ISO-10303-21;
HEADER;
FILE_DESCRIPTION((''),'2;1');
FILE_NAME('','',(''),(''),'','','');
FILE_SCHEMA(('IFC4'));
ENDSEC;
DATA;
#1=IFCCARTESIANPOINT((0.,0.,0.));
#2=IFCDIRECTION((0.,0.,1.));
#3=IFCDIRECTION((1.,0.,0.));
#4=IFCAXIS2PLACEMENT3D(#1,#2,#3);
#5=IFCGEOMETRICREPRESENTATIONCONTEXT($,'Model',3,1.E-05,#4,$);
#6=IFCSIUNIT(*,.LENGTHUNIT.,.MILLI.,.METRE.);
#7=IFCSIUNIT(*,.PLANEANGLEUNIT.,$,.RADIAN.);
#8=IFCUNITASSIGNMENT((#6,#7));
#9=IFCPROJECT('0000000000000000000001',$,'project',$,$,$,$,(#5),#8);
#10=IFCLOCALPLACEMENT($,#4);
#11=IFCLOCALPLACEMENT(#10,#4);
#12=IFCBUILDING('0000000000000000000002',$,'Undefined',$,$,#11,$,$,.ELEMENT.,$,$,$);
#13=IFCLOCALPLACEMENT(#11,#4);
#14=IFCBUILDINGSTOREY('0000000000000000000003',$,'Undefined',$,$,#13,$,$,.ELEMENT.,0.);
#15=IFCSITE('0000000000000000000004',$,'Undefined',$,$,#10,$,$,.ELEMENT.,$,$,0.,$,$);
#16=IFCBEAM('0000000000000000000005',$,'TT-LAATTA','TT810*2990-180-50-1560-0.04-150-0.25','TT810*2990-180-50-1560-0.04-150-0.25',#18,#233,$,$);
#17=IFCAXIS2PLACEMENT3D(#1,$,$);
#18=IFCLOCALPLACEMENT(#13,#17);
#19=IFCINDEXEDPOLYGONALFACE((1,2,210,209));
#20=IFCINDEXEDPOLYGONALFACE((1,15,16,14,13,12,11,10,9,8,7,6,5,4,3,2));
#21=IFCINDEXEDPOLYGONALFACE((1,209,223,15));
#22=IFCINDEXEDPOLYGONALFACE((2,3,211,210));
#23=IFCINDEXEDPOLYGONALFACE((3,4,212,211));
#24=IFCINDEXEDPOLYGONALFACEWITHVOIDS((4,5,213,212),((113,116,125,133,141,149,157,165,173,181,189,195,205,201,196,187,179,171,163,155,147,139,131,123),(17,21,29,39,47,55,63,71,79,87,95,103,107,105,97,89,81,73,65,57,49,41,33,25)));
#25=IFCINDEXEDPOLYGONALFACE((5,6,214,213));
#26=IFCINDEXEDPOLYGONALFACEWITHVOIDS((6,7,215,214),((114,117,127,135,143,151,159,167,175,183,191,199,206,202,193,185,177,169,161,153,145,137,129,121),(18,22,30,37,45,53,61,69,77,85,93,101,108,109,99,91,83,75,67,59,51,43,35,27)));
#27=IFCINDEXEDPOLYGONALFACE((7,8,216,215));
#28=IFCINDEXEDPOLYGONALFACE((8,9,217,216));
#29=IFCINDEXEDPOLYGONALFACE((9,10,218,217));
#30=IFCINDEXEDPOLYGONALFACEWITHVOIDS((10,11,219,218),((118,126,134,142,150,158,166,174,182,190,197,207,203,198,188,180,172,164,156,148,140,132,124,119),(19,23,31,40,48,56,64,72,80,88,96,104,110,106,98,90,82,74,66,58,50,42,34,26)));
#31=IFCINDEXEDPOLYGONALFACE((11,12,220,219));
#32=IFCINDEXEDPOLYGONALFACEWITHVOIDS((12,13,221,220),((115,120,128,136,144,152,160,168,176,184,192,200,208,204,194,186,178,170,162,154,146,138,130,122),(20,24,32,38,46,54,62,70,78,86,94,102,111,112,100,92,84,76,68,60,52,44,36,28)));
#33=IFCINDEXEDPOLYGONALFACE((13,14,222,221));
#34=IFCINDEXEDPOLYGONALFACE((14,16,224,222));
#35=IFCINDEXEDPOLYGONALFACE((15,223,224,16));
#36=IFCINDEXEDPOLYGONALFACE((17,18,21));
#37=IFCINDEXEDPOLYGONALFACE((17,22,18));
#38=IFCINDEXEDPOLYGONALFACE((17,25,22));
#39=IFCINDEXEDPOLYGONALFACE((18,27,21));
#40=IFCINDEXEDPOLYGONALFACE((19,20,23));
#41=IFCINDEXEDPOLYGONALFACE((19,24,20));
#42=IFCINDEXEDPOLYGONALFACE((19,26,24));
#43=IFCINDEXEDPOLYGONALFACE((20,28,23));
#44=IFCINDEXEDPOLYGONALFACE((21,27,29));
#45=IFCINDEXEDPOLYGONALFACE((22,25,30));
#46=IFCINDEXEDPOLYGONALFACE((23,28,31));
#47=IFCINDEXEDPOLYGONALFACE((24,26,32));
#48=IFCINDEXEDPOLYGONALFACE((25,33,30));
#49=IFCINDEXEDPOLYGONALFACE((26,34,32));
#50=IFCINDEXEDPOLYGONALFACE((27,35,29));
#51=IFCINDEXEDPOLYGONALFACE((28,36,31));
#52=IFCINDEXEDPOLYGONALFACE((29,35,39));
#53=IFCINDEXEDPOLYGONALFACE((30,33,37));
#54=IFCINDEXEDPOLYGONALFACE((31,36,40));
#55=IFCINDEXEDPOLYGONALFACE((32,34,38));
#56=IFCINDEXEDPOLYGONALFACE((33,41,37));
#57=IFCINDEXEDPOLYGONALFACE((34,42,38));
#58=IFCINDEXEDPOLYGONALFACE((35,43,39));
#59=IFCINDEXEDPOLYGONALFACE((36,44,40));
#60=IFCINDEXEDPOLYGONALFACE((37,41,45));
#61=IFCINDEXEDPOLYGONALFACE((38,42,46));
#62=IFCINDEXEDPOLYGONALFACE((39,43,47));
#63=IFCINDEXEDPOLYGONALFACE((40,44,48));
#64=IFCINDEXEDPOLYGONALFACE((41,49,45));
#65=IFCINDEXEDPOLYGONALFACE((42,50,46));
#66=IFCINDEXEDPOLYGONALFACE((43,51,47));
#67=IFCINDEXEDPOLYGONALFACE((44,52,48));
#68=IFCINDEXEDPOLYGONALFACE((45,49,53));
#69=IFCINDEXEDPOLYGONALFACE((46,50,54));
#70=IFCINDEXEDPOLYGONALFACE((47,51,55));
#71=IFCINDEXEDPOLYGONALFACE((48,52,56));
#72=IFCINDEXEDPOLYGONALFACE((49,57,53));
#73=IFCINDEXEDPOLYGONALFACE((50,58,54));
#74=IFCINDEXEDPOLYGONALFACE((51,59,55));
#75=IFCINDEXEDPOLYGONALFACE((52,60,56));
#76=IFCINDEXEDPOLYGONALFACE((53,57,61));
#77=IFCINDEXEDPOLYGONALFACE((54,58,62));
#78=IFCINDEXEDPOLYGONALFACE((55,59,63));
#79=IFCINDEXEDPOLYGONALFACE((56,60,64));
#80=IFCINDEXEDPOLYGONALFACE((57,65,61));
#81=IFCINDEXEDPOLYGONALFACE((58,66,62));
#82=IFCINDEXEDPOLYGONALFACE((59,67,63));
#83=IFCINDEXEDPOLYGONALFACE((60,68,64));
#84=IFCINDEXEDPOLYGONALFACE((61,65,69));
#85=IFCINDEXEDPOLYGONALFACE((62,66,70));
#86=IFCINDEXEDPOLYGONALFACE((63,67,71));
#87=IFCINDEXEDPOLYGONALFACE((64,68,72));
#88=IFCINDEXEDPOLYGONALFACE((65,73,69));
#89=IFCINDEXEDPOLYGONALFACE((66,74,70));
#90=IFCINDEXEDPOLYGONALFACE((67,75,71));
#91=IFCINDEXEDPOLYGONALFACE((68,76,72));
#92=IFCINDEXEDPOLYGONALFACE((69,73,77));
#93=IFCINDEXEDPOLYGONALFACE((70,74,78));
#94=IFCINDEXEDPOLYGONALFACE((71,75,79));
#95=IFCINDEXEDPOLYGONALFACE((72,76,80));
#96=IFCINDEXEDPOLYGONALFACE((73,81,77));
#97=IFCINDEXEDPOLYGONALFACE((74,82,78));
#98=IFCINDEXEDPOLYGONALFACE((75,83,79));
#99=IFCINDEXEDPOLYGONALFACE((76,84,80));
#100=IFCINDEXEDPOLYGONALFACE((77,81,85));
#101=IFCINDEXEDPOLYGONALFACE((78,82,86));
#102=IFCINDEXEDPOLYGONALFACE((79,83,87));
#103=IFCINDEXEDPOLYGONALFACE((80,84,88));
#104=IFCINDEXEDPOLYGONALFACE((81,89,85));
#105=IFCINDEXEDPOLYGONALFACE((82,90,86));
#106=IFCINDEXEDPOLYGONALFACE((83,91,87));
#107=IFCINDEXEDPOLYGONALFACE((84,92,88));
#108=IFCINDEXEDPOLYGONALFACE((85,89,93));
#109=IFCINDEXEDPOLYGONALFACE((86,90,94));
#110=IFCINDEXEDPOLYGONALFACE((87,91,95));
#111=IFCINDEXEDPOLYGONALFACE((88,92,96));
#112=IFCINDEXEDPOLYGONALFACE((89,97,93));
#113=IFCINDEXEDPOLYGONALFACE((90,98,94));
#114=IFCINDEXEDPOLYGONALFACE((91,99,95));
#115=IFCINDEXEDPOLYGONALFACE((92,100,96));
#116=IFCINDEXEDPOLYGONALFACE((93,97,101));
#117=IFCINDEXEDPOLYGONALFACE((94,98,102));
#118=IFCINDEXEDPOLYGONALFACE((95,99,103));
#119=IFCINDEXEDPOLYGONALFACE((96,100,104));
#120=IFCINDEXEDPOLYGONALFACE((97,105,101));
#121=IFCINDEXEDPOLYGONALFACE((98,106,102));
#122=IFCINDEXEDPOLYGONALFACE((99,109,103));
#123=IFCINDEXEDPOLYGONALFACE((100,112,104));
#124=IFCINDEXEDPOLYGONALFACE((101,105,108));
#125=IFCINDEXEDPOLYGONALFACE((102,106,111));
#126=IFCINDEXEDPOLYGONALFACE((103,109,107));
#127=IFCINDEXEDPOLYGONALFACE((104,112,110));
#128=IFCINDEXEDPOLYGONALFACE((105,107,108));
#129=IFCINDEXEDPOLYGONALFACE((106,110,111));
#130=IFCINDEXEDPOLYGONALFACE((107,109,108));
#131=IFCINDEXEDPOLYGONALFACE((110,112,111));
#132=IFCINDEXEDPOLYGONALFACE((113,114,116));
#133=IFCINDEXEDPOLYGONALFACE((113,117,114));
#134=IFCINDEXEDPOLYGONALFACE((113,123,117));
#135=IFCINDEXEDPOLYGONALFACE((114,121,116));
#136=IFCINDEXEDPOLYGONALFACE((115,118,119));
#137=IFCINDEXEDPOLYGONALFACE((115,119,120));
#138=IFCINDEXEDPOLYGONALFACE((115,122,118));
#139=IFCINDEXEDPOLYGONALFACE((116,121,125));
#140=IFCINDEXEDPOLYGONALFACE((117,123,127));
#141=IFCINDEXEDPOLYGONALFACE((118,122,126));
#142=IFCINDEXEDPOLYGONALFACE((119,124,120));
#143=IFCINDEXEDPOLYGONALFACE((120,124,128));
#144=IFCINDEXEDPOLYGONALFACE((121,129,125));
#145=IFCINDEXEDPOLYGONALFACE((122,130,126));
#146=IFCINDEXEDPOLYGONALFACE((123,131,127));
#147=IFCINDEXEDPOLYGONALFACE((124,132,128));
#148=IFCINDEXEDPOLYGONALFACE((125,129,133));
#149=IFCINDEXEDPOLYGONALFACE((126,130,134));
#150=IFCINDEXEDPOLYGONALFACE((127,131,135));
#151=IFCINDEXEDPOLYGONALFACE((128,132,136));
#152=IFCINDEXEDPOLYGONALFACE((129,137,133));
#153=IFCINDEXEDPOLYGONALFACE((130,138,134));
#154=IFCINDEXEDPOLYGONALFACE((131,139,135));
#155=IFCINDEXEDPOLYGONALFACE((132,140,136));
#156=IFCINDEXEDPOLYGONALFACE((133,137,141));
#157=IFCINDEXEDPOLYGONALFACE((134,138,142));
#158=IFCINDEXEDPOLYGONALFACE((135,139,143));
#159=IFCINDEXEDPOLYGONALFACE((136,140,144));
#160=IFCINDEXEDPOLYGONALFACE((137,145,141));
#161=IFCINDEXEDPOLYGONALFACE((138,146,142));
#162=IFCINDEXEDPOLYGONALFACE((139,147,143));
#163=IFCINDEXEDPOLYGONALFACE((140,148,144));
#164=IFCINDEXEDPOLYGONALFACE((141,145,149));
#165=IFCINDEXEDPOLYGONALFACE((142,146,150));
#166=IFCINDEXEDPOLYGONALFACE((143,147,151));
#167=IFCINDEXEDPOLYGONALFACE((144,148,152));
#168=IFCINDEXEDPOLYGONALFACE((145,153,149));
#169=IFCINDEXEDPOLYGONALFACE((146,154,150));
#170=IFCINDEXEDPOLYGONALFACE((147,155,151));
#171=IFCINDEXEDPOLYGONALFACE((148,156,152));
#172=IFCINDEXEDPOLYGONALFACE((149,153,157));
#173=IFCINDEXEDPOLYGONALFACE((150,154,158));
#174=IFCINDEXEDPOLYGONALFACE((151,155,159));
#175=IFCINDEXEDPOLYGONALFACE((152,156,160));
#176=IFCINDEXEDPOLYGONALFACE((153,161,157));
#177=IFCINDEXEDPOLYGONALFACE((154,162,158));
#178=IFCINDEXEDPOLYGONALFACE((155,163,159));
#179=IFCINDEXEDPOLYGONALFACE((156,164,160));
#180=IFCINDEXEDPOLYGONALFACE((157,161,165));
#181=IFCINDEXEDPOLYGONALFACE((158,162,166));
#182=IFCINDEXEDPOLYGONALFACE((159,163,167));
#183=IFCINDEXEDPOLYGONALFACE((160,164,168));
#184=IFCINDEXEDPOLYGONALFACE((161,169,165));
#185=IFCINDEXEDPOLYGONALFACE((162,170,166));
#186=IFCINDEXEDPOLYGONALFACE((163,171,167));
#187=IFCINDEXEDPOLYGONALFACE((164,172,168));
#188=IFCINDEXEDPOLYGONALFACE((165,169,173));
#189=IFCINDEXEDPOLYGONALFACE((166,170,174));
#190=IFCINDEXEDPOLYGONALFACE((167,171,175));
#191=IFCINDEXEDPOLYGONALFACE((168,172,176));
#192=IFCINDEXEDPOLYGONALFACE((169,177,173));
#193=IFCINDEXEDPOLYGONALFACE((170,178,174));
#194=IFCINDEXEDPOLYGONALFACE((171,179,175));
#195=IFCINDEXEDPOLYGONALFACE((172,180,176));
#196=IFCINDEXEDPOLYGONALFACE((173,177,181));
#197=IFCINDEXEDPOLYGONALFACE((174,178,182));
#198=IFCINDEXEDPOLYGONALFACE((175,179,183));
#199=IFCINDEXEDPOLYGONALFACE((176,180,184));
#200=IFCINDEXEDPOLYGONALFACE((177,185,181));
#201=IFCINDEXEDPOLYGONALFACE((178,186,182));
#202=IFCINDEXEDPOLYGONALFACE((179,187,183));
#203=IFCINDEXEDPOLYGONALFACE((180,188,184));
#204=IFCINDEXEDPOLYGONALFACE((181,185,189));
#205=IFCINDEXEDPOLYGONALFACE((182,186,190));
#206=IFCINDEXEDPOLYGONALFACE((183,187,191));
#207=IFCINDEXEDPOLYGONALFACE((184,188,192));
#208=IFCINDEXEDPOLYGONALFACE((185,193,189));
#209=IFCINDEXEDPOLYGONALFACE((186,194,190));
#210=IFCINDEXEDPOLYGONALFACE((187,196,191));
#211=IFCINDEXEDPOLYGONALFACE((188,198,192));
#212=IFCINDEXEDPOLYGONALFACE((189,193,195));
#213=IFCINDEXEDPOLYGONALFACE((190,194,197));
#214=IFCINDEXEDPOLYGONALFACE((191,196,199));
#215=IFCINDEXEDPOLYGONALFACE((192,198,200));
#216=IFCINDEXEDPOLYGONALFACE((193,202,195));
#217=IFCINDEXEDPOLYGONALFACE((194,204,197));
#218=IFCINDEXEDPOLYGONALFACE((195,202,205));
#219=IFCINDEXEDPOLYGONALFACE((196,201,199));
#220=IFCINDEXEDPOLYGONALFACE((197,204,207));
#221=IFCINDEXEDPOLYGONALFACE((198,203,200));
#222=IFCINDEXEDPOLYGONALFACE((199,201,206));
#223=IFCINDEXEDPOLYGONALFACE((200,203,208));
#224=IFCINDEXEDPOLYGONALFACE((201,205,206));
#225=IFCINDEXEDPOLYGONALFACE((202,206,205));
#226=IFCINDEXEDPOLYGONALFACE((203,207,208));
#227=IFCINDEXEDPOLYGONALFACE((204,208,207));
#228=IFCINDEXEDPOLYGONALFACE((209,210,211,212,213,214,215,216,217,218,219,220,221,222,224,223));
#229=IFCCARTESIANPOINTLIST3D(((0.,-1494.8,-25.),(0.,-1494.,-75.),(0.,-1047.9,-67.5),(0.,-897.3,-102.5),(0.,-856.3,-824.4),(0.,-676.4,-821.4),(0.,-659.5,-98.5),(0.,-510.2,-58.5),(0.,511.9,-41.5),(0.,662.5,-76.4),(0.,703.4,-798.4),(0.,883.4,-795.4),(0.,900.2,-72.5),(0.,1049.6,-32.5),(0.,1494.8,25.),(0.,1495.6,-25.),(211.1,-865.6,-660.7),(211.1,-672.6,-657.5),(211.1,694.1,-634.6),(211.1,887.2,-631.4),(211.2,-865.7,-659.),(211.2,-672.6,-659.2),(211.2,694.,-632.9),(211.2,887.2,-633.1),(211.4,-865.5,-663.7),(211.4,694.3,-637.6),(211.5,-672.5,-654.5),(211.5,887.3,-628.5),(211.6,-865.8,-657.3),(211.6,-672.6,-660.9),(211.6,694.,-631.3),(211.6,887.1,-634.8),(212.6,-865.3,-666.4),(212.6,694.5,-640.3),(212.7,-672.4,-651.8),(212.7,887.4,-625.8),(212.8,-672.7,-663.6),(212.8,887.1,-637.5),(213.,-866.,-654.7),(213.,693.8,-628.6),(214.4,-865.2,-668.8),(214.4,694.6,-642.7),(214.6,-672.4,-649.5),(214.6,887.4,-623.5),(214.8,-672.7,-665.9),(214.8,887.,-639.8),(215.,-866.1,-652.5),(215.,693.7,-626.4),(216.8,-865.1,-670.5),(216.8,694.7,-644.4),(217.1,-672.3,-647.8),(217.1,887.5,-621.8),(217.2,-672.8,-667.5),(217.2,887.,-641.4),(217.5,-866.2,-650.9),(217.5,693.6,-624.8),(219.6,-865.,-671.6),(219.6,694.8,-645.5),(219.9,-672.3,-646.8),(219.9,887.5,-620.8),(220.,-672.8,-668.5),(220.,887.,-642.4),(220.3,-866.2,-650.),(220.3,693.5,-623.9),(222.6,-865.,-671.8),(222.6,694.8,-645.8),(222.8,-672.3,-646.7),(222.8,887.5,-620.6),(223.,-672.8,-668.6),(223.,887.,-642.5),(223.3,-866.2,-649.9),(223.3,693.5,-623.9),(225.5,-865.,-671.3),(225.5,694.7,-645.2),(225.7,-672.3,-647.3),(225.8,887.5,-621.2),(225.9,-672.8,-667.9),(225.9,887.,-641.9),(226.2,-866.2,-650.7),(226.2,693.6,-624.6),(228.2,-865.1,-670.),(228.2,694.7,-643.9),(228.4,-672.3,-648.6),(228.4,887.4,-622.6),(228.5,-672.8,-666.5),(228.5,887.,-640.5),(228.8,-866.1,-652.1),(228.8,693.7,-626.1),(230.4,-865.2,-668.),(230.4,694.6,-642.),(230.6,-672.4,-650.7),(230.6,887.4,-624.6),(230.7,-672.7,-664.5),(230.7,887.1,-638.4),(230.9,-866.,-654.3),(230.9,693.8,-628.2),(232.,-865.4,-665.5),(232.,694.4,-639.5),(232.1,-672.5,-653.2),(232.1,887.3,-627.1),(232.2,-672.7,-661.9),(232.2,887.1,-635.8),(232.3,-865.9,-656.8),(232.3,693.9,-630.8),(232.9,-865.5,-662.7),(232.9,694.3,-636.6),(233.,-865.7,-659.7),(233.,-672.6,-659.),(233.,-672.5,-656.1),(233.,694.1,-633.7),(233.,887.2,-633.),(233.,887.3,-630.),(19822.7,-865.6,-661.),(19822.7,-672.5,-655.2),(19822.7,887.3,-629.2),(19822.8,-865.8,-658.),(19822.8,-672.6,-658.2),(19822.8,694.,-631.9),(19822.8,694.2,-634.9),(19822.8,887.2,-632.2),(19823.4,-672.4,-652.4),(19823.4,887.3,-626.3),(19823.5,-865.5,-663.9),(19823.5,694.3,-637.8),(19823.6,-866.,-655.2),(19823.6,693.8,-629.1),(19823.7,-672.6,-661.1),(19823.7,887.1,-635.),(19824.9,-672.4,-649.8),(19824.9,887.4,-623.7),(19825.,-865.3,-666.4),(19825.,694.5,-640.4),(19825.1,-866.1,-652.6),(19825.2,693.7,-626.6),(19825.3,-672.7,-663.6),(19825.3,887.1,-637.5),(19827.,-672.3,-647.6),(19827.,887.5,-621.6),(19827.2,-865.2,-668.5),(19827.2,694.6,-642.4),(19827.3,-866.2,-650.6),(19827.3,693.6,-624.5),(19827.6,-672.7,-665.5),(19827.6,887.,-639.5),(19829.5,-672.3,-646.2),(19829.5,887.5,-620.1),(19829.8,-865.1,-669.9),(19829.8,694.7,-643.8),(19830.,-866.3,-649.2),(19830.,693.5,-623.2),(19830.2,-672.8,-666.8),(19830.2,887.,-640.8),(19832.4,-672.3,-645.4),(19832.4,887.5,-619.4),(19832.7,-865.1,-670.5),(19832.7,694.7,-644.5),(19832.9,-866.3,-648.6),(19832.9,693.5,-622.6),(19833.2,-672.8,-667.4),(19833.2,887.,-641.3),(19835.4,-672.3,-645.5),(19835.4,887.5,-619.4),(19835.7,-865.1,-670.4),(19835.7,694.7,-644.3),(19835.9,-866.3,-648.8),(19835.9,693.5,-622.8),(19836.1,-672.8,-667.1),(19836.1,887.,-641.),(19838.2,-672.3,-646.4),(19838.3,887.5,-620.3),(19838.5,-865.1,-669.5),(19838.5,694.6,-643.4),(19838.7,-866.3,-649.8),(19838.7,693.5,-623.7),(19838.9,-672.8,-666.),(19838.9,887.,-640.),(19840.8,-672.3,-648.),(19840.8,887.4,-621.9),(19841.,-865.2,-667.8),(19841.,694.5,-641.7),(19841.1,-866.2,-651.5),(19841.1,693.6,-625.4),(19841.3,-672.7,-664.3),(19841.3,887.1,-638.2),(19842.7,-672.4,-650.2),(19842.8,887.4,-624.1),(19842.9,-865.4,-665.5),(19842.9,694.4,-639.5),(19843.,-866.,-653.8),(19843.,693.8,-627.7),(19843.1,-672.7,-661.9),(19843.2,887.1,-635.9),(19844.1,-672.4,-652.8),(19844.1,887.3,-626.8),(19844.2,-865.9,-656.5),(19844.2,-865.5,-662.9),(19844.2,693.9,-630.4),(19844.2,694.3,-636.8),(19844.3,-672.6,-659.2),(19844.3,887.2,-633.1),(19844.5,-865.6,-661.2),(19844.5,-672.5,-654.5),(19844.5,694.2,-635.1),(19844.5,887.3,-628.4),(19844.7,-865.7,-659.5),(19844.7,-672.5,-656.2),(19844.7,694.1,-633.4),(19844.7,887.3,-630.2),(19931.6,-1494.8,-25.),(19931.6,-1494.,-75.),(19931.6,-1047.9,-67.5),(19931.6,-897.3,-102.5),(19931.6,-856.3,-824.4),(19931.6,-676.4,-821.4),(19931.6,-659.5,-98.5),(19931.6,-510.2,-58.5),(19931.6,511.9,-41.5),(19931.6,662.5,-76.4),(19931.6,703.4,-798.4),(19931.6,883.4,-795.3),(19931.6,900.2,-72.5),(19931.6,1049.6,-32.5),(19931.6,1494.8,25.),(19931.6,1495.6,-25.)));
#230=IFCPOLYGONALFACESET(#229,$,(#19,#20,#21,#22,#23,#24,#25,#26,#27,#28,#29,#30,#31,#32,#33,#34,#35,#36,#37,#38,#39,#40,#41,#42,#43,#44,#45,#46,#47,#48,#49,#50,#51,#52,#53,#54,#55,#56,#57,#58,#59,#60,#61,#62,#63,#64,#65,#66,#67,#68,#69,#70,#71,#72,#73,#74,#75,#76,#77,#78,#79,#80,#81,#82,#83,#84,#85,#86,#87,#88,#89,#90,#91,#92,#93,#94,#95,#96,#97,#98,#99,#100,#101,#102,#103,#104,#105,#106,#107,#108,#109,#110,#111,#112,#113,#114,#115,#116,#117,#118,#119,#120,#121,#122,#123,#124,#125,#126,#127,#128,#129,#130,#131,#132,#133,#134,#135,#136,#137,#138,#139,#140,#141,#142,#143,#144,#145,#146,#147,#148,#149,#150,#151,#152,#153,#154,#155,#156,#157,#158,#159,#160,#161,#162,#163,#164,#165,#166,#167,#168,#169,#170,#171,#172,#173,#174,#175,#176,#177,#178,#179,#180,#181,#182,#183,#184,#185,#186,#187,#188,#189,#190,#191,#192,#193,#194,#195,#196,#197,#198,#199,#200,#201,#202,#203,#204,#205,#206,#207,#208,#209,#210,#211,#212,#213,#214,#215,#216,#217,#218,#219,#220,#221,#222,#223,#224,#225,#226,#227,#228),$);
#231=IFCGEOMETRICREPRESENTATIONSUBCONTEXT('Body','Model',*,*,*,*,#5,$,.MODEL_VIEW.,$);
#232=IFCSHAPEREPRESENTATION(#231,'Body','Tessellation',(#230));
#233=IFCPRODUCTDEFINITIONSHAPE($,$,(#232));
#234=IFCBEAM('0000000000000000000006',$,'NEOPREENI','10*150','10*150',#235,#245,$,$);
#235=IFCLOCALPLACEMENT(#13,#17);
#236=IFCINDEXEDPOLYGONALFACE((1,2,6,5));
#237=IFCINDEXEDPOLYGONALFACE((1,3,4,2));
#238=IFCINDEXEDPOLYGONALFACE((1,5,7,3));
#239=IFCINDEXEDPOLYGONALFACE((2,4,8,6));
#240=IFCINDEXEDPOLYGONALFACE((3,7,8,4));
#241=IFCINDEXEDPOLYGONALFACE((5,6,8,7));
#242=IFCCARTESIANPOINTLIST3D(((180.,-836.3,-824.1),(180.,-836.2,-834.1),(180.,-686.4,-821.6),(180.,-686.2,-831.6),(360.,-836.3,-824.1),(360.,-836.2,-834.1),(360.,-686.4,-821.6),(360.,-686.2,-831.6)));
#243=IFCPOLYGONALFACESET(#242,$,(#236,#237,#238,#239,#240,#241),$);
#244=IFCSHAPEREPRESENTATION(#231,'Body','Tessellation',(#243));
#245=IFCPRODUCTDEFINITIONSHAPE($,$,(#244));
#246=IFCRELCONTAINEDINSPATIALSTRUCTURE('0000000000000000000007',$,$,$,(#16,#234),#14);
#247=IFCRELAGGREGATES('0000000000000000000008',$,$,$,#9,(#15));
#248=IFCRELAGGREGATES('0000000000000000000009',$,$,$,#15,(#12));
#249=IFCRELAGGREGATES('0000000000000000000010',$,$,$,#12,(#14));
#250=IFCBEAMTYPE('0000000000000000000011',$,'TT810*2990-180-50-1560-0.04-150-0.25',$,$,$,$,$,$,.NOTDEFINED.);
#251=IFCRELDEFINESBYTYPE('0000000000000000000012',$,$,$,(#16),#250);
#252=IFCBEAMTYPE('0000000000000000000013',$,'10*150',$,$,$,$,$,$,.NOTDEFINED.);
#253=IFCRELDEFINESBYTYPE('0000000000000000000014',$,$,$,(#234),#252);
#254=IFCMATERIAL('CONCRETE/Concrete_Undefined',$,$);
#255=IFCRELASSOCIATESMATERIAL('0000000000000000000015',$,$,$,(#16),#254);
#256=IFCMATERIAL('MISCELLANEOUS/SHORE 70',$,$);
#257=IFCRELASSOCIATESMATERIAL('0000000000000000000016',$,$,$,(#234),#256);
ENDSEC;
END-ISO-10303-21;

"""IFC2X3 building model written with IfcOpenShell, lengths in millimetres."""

from ifc_helpers import new_model, si_unit, frame, origin_with_axes, origin_2d_with_axis, place, context, subcontext, project, spatial, polyline, rectangle, circle, outline, extrude, boolean, material, type_object, element, save


model = new_model("IFC2X3")

# Units and contexts
model_context = context("Model", 3, precision=1e-05, world=origin_with_axes())
body_context = subcontext(model_context, "Body", "Model", "MODEL_VIEW")
ifc_project = project(units=[si_unit("LENGTHUNIT", "METRE", prefix="MILLI"), si_unit("PLANEANGLEUNIT", "RADIAN")], contexts=[model_context])

# Site, building, storey
site_placement = place(None, origin_with_axes())
site = spatial("IfcSite", under=ifc_project, at=site_placement, Name="Undefined", CompositionType="ELEMENT", RefElevation=0.0)
building_placement = place(site_placement, origin_with_axes())
building = spatial("IfcBuilding", under=site, at=building_placement, Name="Undefined", CompositionType="ELEMENT")
storey_placement = place(building_placement, origin_with_axes())
storey = spatial("IfcBuildingStorey", under=building, at=storey_placement, Name="Undefined", CompositionType="ELEMENT", Elevation=0.0)

# Beams
ifc_material_1 = material(Name="CONCRETE/Concrete_Undefined")
beam_type_1 = type_object("IfcBeamType", Name="TT810*2990-180-50-1560-0.04-150-0.25", PredefinedType="NOTDEFINED")
beam_1_placement = place(storey_placement, frame((0.0, 6.8, -404.9), z_axis=(0.0, -0.016714, 0.99986), x_axis=(1.0, 0.0, 0.0)))
element("IfcBeam", 1, at=beam_1_placement, inside=storey, type_object=beam_type_1, material=ifc_material_1, Name="TT-LAATTA", Description="TT810*2990-180-50-1560-0.04-150-0.25", ObjectType="TT810*2990-180-50-1560-0.04-150-0.25", context=body_context, shape_type="CSG", body=[
    boolean("DIFFERENCE", boolean("DIFFERENCE", boolean("DIFFERENCE", boolean("DIFFERENCE", extrude(outline(polyline([(-1048.9, 355.0), (-1495.0, 355.0), (-1495.0, 405.0), (1495.0, 405.0), (1495.0, 355.0), (1048.9, 355.0), (898.9, 317.5), (870.0, -405.0), (690.0, -405.0), (661.1, 317.5), (511.1, 355.0), (-511.1, 355.0), (-661.1, 317.5), (-690.0, -405.0), (-870.0, -405.0), (-898.9, 317.5), (-1048.9, 355.0)])), frame((19931.6, 0.0, 0.0), z_axis=(-1.0, 0.0, 0.0), x_axis=(0.0, -1.0, 0.0)), (0.0, 0.0, 1.0), 19931.6), extrude(circle(Radius=11.0, at=origin_2d_with_axis()), frame((19833.7, 977.2, -240.0), z_axis=(0.0, -1.0, 0.0), x_axis=(0.999921, 0.0, 0.012601)), (0.0, 0.0, 1.0), 380.0)), extrude(circle(Radius=11.0, at=origin_2d_with_axis()), frame((19833.7, -582.8, -240.0), z_axis=(0.0, -1.0, 0.0), x_axis=(0.999921, 0.0, 0.012601)), (0.0, 0.0, 1.0), 380.0)), extrude(circle(Radius=11.0, at=origin_2d_with_axis()), frame((222.1, -962.7, -241.3), z_axis=(0.0, 1.0, 0.0), x_axis=(-0.999921, 0.0, 0.012601)), (0.0, 0.0, 1.0), 380.0)), extrude(circle(Radius=11.0, at=origin_2d_with_axis()), frame((222.1, 597.3, -241.3), z_axis=(0.0, 1.0, 0.0), x_axis=(-0.999921, 0.0, 0.012601)), (0.0, 0.0, 1.0), 380.0)),
])
ifc_material_2 = material(Name="MISCELLANEOUS/SHORE 70")
beam_type_2 = type_object("IfcBeamType", Name="10*150", PredefinedType="NOTDEFINED")
beam_2_placement = place(storey_placement, frame((180.0, -761.3, -827.8), z_axis=(-0.000005, -0.016723, 0.99986), x_axis=(1.0, 0.000015, 0.000005)))
element("IfcBeam", 2, at=beam_2_placement, inside=storey, type_object=beam_type_2, material=ifc_material_2, Name="NEOPREENI", Description="10*150", ObjectType="10*150", context=body_context, shape_type="SweptSolid", body=[
    extrude(rectangle(XDim=150.0, YDim=10.0, at=origin_2d_with_axis()), frame((180.0, 0.0, 0.0), z_axis=(-1.0, 0.0, 0.0), x_axis=(0.0, -1.0, 0.0)), (0.0, 0.0, 1.0), 180.0),
])

save(model, "model.ifc")
